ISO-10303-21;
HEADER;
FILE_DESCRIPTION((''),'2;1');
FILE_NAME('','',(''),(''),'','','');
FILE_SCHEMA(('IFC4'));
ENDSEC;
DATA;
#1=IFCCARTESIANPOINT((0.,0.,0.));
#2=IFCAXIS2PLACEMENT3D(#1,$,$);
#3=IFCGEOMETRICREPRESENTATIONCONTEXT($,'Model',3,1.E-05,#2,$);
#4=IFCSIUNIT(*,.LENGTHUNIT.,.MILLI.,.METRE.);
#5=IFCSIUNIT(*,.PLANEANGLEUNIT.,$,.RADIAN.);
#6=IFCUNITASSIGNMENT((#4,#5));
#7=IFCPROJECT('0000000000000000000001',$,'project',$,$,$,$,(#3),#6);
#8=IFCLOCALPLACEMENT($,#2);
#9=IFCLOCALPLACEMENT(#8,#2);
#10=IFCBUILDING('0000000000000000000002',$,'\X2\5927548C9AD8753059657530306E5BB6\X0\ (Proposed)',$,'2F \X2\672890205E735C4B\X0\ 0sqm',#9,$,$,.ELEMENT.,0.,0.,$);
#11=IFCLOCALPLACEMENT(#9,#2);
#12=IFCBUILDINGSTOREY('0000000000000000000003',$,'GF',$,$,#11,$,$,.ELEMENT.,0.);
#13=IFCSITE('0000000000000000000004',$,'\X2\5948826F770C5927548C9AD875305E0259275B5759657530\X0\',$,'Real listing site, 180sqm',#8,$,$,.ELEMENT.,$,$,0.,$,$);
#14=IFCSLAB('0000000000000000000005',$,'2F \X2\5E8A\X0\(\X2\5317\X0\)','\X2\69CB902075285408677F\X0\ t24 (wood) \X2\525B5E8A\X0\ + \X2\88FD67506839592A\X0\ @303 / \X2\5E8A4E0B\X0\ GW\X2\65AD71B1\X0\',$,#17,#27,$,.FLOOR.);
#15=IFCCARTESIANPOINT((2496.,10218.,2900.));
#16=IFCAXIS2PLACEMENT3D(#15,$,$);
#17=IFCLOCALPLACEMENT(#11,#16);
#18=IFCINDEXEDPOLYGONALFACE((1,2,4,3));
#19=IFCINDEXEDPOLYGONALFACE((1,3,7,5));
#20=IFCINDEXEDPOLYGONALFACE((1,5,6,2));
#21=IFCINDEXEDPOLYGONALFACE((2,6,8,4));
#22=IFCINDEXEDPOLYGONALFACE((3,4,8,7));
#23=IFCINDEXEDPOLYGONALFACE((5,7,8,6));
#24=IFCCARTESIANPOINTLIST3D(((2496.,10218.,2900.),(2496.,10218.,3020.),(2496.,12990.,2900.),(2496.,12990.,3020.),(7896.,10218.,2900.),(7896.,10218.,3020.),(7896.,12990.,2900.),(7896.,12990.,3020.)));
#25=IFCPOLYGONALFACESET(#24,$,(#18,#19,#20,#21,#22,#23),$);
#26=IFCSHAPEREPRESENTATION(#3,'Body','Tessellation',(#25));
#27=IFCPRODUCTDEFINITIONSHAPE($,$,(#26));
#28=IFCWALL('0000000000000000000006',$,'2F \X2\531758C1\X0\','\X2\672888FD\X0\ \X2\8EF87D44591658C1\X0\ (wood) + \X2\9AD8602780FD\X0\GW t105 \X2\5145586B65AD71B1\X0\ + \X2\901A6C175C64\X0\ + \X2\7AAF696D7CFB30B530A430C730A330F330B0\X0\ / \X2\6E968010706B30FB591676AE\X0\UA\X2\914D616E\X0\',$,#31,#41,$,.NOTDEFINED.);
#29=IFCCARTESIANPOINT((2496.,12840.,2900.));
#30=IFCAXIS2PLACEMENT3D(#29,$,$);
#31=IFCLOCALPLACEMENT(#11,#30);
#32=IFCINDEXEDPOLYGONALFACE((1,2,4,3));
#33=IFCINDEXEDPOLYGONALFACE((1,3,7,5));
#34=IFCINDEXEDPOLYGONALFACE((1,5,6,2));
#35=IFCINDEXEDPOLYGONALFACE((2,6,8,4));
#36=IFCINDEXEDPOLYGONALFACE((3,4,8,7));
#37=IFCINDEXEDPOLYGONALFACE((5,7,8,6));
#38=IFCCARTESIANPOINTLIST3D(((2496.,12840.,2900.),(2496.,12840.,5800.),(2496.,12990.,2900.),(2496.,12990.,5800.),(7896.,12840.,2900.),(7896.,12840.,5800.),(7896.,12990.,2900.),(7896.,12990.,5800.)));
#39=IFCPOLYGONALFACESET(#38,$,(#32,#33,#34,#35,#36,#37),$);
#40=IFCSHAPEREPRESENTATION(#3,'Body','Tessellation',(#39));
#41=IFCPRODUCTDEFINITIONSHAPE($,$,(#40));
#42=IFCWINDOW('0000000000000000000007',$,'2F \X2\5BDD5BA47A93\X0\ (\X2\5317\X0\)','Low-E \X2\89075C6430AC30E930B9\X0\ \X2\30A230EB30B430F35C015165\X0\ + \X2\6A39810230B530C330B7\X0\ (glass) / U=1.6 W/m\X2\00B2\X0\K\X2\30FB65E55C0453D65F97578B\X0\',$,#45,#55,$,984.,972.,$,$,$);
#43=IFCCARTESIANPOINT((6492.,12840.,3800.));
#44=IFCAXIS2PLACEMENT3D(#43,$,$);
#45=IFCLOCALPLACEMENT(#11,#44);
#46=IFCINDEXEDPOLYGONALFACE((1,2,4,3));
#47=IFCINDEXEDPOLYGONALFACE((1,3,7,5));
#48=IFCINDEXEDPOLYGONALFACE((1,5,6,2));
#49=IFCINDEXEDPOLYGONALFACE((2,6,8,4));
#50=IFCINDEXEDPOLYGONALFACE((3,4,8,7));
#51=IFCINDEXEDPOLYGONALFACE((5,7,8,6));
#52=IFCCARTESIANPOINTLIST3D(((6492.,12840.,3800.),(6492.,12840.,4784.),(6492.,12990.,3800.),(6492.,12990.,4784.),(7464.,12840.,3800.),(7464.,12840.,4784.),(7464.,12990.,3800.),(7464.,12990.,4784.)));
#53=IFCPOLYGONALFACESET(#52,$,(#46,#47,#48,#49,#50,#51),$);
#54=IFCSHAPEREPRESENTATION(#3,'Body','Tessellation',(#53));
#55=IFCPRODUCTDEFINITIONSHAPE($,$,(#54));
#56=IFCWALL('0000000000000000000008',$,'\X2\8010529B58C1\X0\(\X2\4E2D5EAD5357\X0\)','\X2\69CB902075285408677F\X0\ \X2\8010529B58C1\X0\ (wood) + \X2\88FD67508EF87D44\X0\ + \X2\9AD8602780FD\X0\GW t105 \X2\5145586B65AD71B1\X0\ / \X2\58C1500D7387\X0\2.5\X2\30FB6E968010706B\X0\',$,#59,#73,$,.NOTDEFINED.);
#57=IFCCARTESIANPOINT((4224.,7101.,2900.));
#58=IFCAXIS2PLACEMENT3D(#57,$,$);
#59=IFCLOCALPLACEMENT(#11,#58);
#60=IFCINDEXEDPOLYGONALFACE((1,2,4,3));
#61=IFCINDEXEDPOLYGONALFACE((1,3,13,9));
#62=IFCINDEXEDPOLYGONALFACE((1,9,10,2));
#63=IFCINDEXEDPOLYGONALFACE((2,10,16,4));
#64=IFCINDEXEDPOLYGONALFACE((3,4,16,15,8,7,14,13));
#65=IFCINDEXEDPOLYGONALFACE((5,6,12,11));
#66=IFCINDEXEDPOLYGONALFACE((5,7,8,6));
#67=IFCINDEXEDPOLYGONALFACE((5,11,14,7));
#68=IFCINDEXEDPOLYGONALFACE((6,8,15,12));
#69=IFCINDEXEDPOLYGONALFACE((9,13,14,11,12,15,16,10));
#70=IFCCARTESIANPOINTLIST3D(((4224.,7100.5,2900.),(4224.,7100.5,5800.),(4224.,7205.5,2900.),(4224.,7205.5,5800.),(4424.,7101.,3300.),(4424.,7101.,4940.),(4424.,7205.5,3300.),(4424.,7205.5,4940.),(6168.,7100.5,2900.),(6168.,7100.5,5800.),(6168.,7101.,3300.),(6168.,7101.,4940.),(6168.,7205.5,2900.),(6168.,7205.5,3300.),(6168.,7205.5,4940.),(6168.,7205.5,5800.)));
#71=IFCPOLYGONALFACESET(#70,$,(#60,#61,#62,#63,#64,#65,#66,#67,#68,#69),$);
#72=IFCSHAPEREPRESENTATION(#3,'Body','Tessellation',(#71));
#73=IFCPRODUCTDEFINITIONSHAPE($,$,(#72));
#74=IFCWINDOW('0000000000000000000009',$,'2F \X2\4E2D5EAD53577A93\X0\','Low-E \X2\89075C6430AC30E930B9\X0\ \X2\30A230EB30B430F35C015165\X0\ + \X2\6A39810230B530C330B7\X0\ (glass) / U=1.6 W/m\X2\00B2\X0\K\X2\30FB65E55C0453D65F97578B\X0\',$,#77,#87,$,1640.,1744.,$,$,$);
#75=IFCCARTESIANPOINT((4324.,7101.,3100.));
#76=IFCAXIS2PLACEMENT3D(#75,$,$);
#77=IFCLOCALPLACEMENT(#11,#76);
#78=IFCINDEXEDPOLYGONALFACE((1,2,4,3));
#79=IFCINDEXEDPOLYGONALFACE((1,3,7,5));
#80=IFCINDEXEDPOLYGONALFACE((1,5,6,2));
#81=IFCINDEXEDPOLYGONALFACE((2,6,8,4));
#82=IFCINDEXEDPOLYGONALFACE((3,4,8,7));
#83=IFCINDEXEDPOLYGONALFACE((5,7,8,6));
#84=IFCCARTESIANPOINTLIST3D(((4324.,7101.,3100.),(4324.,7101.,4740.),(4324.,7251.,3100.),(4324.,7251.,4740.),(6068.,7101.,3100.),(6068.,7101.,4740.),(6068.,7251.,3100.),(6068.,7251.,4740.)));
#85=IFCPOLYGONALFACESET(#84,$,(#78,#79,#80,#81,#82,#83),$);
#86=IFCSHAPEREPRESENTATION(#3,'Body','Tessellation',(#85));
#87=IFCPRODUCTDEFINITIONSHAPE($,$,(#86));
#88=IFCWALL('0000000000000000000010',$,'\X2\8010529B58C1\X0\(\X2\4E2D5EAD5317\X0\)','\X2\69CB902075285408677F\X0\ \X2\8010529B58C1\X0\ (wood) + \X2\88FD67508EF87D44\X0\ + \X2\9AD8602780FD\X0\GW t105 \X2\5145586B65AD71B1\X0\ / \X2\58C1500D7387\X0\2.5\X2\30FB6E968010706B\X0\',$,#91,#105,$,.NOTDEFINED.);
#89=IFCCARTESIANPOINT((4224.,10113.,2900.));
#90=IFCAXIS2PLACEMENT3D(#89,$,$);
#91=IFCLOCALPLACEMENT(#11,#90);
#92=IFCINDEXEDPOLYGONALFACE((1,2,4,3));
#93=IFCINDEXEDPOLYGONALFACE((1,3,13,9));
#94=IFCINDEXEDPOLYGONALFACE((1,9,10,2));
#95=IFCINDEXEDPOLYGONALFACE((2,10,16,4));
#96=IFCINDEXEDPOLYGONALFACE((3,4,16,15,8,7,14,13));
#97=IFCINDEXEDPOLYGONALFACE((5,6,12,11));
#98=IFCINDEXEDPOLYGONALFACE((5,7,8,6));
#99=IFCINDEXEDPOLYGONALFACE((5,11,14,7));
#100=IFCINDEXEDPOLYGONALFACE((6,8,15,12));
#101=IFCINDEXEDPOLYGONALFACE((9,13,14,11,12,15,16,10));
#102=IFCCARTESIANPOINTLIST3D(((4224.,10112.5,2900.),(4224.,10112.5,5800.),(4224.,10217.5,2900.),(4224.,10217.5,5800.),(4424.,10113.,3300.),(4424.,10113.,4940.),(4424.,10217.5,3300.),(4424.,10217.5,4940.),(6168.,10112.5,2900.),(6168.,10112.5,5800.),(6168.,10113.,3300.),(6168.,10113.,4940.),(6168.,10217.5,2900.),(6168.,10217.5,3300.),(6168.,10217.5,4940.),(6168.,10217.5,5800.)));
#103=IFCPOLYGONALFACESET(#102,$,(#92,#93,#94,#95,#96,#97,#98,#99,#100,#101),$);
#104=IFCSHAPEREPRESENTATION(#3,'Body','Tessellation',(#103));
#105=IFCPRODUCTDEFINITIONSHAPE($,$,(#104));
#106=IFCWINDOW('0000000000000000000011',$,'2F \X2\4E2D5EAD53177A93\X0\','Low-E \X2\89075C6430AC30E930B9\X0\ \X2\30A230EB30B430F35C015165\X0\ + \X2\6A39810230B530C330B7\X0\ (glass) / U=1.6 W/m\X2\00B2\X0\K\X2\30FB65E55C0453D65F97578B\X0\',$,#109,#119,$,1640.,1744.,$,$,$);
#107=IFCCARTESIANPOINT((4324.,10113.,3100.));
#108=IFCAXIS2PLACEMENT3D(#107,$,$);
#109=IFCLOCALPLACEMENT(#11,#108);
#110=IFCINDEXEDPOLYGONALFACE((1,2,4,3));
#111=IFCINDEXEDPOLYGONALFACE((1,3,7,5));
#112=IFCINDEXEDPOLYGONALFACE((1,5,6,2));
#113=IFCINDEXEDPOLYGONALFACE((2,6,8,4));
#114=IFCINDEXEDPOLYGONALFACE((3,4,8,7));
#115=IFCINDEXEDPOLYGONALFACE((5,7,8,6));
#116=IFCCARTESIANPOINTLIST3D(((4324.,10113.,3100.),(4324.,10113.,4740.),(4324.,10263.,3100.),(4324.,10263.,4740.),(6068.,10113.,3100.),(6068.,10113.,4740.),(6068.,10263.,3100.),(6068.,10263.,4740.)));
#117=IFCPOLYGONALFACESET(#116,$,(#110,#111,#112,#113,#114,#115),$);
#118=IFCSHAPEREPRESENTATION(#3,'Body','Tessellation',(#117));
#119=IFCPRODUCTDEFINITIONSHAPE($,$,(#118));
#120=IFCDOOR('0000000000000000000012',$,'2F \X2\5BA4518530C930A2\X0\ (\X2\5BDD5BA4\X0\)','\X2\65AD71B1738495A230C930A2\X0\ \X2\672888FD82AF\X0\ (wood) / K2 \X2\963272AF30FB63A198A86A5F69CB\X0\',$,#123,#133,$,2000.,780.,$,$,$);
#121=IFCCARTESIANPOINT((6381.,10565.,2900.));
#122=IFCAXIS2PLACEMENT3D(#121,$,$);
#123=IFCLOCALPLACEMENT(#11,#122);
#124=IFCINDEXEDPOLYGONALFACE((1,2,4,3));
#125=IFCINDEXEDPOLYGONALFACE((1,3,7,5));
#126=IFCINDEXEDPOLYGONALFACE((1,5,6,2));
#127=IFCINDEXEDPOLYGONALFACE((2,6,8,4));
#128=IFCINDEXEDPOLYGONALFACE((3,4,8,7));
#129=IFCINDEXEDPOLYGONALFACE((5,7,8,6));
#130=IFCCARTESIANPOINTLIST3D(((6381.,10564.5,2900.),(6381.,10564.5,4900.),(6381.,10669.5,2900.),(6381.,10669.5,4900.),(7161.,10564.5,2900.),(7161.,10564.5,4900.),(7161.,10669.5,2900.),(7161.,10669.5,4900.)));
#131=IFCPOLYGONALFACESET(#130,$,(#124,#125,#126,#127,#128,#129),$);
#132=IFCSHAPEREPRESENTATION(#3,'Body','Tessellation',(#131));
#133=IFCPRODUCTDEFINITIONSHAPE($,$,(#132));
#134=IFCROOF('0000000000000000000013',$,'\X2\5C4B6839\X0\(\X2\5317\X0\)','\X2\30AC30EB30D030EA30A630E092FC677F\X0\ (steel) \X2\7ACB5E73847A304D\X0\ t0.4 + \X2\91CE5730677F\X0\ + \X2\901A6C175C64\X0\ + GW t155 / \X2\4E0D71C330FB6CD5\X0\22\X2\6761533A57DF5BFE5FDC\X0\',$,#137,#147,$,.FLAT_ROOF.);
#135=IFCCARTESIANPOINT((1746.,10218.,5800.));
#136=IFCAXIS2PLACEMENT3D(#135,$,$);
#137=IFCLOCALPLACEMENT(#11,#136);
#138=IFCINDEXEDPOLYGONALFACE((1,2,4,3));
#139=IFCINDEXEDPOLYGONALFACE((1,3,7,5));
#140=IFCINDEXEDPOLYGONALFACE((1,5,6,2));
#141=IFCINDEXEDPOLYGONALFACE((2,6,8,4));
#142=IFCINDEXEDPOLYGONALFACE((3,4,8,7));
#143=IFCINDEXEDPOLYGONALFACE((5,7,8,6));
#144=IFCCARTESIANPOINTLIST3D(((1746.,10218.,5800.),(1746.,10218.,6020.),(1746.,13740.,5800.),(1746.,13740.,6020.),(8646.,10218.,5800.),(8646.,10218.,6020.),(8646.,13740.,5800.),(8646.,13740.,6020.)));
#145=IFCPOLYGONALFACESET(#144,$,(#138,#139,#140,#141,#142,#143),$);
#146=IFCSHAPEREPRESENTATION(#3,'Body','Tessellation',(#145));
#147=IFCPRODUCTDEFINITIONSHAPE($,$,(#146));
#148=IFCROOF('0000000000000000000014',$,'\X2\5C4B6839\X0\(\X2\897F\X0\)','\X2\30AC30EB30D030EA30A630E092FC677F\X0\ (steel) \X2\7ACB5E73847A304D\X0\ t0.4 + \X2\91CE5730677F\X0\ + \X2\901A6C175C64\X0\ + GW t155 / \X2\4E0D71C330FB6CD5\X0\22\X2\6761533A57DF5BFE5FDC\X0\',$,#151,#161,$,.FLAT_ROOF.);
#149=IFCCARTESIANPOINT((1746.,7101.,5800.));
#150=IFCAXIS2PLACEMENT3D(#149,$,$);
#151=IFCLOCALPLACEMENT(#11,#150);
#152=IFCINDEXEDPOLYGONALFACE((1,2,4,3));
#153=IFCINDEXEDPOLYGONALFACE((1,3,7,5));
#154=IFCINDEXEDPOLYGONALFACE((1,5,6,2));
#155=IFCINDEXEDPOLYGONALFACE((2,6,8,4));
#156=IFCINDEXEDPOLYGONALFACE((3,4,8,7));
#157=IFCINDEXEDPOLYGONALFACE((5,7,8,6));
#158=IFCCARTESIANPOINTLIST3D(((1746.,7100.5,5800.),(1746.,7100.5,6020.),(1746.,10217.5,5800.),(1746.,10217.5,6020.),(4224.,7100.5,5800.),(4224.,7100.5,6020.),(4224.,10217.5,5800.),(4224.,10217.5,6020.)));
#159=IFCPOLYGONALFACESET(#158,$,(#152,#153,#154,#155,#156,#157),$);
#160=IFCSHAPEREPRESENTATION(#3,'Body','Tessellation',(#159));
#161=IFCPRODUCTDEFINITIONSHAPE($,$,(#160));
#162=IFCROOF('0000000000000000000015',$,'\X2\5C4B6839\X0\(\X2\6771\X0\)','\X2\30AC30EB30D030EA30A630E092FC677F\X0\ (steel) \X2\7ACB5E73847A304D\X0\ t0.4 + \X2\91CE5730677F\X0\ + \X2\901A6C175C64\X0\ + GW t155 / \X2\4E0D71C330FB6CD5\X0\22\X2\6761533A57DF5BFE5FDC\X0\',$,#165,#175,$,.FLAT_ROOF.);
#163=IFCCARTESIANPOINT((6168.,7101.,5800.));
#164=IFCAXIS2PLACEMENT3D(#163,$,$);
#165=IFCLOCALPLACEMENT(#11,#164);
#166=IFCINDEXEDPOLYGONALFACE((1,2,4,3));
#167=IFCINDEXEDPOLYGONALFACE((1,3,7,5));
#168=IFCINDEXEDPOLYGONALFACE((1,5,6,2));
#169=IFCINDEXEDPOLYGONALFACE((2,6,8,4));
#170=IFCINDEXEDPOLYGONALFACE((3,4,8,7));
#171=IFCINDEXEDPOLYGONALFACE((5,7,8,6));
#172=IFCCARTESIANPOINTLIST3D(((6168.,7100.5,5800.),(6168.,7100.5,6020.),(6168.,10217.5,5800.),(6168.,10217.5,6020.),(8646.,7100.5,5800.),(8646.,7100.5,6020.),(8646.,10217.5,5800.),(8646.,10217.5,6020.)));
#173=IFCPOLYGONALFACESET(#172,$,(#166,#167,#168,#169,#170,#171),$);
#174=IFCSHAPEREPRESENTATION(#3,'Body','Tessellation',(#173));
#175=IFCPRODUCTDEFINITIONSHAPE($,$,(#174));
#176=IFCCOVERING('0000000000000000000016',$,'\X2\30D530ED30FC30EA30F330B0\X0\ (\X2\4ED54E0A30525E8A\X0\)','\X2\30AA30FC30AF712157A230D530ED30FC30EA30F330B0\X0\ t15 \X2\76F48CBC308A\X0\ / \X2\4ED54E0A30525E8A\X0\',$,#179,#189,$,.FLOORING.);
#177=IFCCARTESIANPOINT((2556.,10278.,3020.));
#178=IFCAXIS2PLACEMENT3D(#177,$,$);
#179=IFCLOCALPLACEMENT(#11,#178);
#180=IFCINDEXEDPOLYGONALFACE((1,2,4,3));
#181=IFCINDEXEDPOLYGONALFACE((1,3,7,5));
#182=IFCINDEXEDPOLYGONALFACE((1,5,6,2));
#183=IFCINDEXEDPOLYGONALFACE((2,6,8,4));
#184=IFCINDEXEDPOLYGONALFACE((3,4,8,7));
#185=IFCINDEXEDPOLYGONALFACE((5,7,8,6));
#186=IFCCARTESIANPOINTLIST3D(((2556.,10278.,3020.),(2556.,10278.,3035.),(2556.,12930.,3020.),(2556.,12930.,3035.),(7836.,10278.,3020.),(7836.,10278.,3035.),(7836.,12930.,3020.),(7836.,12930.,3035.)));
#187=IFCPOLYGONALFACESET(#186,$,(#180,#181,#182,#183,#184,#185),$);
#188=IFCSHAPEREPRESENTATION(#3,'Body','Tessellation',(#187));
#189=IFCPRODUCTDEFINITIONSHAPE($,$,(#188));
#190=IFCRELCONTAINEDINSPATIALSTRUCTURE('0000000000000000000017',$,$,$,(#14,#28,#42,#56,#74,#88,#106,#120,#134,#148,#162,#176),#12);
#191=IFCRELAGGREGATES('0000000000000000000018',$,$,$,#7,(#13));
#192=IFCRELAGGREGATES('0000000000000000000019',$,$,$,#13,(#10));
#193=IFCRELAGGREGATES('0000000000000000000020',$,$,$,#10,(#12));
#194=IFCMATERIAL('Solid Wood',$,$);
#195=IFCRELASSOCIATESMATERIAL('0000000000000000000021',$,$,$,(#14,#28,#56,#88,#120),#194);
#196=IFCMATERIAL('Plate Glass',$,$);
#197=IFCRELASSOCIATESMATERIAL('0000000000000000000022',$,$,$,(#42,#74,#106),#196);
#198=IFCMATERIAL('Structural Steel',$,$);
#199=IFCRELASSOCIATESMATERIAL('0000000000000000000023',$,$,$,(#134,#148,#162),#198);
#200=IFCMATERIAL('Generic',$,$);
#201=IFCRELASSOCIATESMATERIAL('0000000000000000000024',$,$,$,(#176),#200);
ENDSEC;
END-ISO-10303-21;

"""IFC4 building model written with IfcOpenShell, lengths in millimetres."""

from ifc_helpers import new_model, si_unit, frame, frame_2d, origin, place, context, project, spatial, rectangle, extrude, material, element, fill, save


model = new_model("IFC4")

# Units and contexts
model_context = context("Model", 3, precision=1e-05, world=origin())
ifc_project = project(units=[si_unit("LENGTHUNIT", "METRE", prefix="MILLI"), si_unit("PLANEANGLEUNIT", "RADIAN")], contexts=[model_context])

# Site, building, storey
site_placement = place(None, origin())
site = spatial("IfcSite", under=ifc_project, at=site_placement, Name="奈良県大和高田市大字奥田", ObjectType="Real listing site, 180sqm", CompositionType="ELEMENT", RefElevation=0.0)
building_placement = place(site_placement, origin())
building = spatial("IfcBuilding", under=site, at=building_placement, Name="大和高田奥田の家 (Proposed)", ObjectType="2F 木造平屋 0sqm", CompositionType="ELEMENT", ElevationOfRefHeight=0.0, ElevationOfTerrain=0.0)
storey_placement = place(building_placement, origin())
storey = spatial("IfcBuildingStorey", under=building, at=storey_placement, Name="GF", CompositionType="ELEMENT", Elevation=0.0)

# Slab
ifc_material_1 = material(Name="Solid Wood")
slab_placement = place(storey_placement, frame((2496.0, 10218.0, 2900.0)))
element("IfcSlab", 1, at=slab_placement, inside=storey, material=ifc_material_1, Name="2F 床(北)", Description="構造用合板 t24 (wood) 剛床 + 製材根太 @303 / 床下 GW断熱", PredefinedType="FLOOR", context=model_context, shape_type="SweptSolid", body=[
    extrude(rectangle(XDim=5400.0, YDim=2772.0, at=frame_2d((2700.0, 1386.0))), frame((2496.0, 10218.0, 2900.0)), (0.0, 0.0, 1.0), 120.0),
])

# Walls, openings, windows
wall_1_placement = place(storey_placement, frame((2496.0, 12840.0, 2900.0)))
wall_1 = element("IfcWall", 2, at=wall_1_placement, inside=storey, material=ifc_material_1, Name="2F 北壁", Description="木製 軸組外壁 (wood) + 高性能GW t105 充填断熱 + 通気層 + 窯業系サイディング / 準耐火・外皮UA配慮", PredefinedType="NOTDEFINED", context=model_context, shape_type="SweptSolid", body=[
    extrude(rectangle(XDim=5400.0, YDim=150.0, at=frame_2d((2700.0, 75.0))), frame((2496.0, 12840.0, 2900.0)), (0.0, 0.0, 1.0), 2900.0),
])
opening_1_placement = place(storey_placement, frame((6492.0, 12840.0, 3800.0)))
opening_1 = element("IfcOpeningElement", 3, at=opening_1_placement, cuts=wall_1, PredefinedType="NOTDEFINED", context=model_context, shape_type="SweptSolid", body=[
    extrude(rectangle(XDim=972.0, YDim=150.0, at=frame_2d((486.0, 75.0))), frame((6492.0, 12840.0, 3800.0)), (0.0, 0.0, 1.0), 984.0),
])
ifc_material_2 = material(Name="Plate Glass")
window_1_placement = place(storey_placement, frame((6492.0, 12840.0, 3800.0)))
window_1 = element("IfcWindow", 4, at=window_1_placement, inside=storey, material=ifc_material_2, Name="2F 寝室窓 (北)", Description="Low-E 複層ガラス アルゴン封入 + 樹脂サッシ (glass) / U=1.6 W/m²K・日射取得型", OverallHeight=984.0, OverallWidth=972.0, context=model_context, shape_type="SweptSolid", body=[
    extrude(rectangle(XDim=972.0, YDim=150.0, at=frame_2d((486.0, 75.0))), frame((6492.0, 12840.0, 3800.0)), (0.0, 0.0, 1.0), 984.0),
])
fill(opening_1, window_1)
wall_2_placement = place(storey_placement, frame((4224.0, 7101.0, 2900.0)))
wall_2 = element("IfcWall", 5, at=wall_2_placement, inside=storey, material=ifc_material_1, Name="耐力壁(中庭南)", Description="構造用合板 耐力壁 (wood) + 製材軸組 + 高性能GW t105 充填断熱 / 壁倍率2.5・準耐火", PredefinedType="NOTDEFINED", context=model_context, shape_type="SweptSolid", body=[
    extrude(rectangle(XDim=1944.0, YDim=105.0, at=frame_2d((972.0, 52.0))), frame((4224.0, 7101.0, 2900.0)), (0.0, 0.0, 1.0), 2900.0),
])
opening_2_placement = place(storey_placement, frame((4324.0, 7101.0, 3100.0)))
opening_2 = element("IfcOpeningElement", 6, at=opening_2_placement, cuts=wall_2, PredefinedType="NOTDEFINED", context=model_context, shape_type="SweptSolid", body=[
    extrude(rectangle(XDim=1744.0, YDim=150.0, at=frame_2d((872.0, 75.0))), frame((4324.0, 7101.0, 3100.0)), (0.0, 0.0, 1.0), 1640.0),
])
window_2_placement = place(storey_placement, frame((4324.0, 7101.0, 3100.0)))
window_2 = element("IfcWindow", 7, at=window_2_placement, inside=storey, material=ifc_material_2, Name="2F 中庭南窓", Description="Low-E 複層ガラス アルゴン封入 + 樹脂サッシ (glass) / U=1.6 W/m²K・日射取得型", OverallHeight=1640.0, OverallWidth=1744.0, context=model_context, shape_type="SweptSolid", body=[
    extrude(rectangle(XDim=1744.0, YDim=150.0, at=frame_2d((872.0, 75.0))), frame((4324.0, 7101.0, 3100.0)), (0.0, 0.0, 1.0), 1640.0),
])
fill(opening_2, window_2)
wall_3_placement = place(storey_placement, frame((4224.0, 10113.0, 2900.0)))
wall_3 = element("IfcWall", 8, at=wall_3_placement, inside=storey, material=ifc_material_1, Name="耐力壁(中庭北)", Description="構造用合板 耐力壁 (wood) + 製材軸組 + 高性能GW t105 充填断熱 / 壁倍率2.5・準耐火", PredefinedType="NOTDEFINED", context=model_context, shape_type="SweptSolid", body=[
    extrude(rectangle(XDim=1944.0, YDim=105.0, at=frame_2d((972.0, 52.0))), frame((4224.0, 10113.0, 2900.0)), (0.0, 0.0, 1.0), 2900.0),
])
opening_3_placement = place(storey_placement, frame((4324.0, 10113.0, 3100.0)))
opening_3 = element("IfcOpeningElement", 9, at=opening_3_placement, cuts=wall_3, PredefinedType="NOTDEFINED", context=model_context, shape_type="SweptSolid", body=[
    extrude(rectangle(XDim=1744.0, YDim=150.0, at=frame_2d((872.0, 75.0))), frame((4324.0, 10113.0, 3100.0)), (0.0, 0.0, 1.0), 1640.0),
])
window_3_placement = place(storey_placement, frame((4324.0, 10113.0, 3100.0)))
window_3 = element("IfcWindow", 10, at=window_3_placement, inside=storey, material=ifc_material_2, Name="2F 中庭北窓", Description="Low-E 複層ガラス アルゴン封入 + 樹脂サッシ (glass) / U=1.6 W/m²K・日射取得型", OverallHeight=1640.0, OverallWidth=1744.0, context=model_context, shape_type="SweptSolid", body=[
    extrude(rectangle(XDim=1744.0, YDim=150.0, at=frame_2d((872.0, 75.0))), frame((4324.0, 10113.0, 3100.0)), (0.0, 0.0, 1.0), 1640.0),
])
fill(opening_3, window_3)

# Door
door_placement = place(storey_placement, frame((6381.0, 10565.0, 2900.0)))
element("IfcDoor", 11, at=door_placement, inside=storey, material=ifc_material_1, Name="2F 室内ドア (寝室)", Description="断熱玄関ドア 木製芯 (wood) / K2 防犯・採風機構", OverallHeight=2000.0, OverallWidth=780.0, context=model_context, shape_type="SweptSolid", body=[
    extrude(rectangle(XDim=780.0, YDim=105.0, at=frame_2d((390.0, 52.0))), frame((6381.0, 10565.0, 2900.0)), (0.0, 0.0, 1.0), 2000.0),
])

# Roofs
ifc_material_3 = material(Name="Structural Steel")
for number, where, name in (
    (12, (1746.0, 10218.0, 5800.0), "屋根(北)"),
):
    element("IfcRoof", number, at=place(storey_placement, frame(where)), inside=storey, material=ifc_material_3, Name=name, Description="ガルバリウム鋼板 (steel) 立平葺き t0.4 + 野地板 + 通気層 + GW t155 / 不燃・法22条区域対応", PredefinedType="FLAT_ROOF", context=model_context, shape_type="SweptSolid", body=[
        extrude(rectangle(XDim=6900.0, YDim=3522.0, at=frame_2d((3450.0, 1761.0))), frame((1746.0, 10218.0, 5800.0)), (0.0, 0.0, 1.0), 220.0),
    ])
roof_1_placement = place(storey_placement, frame((1746.0, 7101.0, 5800.0)))
element("IfcRoof", 13, at=roof_1_placement, inside=storey, material=ifc_material_3, Name="屋根(西)", Description="ガルバリウム鋼板 (steel) 立平葺き t0.4 + 野地板 + 通気層 + GW t155 / 不燃・法22条区域対応", PredefinedType="FLAT_ROOF", context=model_context, shape_type="SweptSolid", body=[
    extrude(rectangle(XDim=2478.0, YDim=3117.0, at=frame_2d((1239.0, 1558.0))), frame((1746.0, 7101.0, 5800.0)), (0.0, 0.0, 1.0), 220.0),
])
roof_2_placement = place(storey_placement, frame((6168.0, 7101.0, 5800.0)))
element("IfcRoof", 14, at=roof_2_placement, inside=storey, material=ifc_material_3, Name="屋根(東)", Description="ガルバリウム鋼板 (steel) 立平葺き t0.4 + 野地板 + 通気層 + GW t155 / 不燃・法22条区域対応", PredefinedType="FLAT_ROOF", context=model_context, shape_type="SweptSolid", body=[
    extrude(rectangle(XDim=2478.0, YDim=3117.0, at=frame_2d((1239.0, 1558.0))), frame((6168.0, 7101.0, 5800.0)), (0.0, 0.0, 1.0), 220.0),
])

# Covering
ifc_material_4 = material(Name="Generic")
covering_1_placement = place(storey_placement, frame((2556.0, 10278.0, 3020.0)))
element("IfcCovering", 15, at=covering_1_placement, inside=storey, material=ifc_material_4, Name="フローリング (仕上げ床)", Description="オーク無垢フローリング t15 直貼り / 仕上げ床", PredefinedType="FLOORING", context=model_context, shape_type="SweptSolid", body=[
    extrude(rectangle(XDim=5280.0, YDim=2652.0, at=frame_2d((2640.0, 1326.0))), frame((2556.0, 10278.0, 3020.0)), (0.0, 0.0, 1.0), 15.0),
])

save(model, "model.ifc")
